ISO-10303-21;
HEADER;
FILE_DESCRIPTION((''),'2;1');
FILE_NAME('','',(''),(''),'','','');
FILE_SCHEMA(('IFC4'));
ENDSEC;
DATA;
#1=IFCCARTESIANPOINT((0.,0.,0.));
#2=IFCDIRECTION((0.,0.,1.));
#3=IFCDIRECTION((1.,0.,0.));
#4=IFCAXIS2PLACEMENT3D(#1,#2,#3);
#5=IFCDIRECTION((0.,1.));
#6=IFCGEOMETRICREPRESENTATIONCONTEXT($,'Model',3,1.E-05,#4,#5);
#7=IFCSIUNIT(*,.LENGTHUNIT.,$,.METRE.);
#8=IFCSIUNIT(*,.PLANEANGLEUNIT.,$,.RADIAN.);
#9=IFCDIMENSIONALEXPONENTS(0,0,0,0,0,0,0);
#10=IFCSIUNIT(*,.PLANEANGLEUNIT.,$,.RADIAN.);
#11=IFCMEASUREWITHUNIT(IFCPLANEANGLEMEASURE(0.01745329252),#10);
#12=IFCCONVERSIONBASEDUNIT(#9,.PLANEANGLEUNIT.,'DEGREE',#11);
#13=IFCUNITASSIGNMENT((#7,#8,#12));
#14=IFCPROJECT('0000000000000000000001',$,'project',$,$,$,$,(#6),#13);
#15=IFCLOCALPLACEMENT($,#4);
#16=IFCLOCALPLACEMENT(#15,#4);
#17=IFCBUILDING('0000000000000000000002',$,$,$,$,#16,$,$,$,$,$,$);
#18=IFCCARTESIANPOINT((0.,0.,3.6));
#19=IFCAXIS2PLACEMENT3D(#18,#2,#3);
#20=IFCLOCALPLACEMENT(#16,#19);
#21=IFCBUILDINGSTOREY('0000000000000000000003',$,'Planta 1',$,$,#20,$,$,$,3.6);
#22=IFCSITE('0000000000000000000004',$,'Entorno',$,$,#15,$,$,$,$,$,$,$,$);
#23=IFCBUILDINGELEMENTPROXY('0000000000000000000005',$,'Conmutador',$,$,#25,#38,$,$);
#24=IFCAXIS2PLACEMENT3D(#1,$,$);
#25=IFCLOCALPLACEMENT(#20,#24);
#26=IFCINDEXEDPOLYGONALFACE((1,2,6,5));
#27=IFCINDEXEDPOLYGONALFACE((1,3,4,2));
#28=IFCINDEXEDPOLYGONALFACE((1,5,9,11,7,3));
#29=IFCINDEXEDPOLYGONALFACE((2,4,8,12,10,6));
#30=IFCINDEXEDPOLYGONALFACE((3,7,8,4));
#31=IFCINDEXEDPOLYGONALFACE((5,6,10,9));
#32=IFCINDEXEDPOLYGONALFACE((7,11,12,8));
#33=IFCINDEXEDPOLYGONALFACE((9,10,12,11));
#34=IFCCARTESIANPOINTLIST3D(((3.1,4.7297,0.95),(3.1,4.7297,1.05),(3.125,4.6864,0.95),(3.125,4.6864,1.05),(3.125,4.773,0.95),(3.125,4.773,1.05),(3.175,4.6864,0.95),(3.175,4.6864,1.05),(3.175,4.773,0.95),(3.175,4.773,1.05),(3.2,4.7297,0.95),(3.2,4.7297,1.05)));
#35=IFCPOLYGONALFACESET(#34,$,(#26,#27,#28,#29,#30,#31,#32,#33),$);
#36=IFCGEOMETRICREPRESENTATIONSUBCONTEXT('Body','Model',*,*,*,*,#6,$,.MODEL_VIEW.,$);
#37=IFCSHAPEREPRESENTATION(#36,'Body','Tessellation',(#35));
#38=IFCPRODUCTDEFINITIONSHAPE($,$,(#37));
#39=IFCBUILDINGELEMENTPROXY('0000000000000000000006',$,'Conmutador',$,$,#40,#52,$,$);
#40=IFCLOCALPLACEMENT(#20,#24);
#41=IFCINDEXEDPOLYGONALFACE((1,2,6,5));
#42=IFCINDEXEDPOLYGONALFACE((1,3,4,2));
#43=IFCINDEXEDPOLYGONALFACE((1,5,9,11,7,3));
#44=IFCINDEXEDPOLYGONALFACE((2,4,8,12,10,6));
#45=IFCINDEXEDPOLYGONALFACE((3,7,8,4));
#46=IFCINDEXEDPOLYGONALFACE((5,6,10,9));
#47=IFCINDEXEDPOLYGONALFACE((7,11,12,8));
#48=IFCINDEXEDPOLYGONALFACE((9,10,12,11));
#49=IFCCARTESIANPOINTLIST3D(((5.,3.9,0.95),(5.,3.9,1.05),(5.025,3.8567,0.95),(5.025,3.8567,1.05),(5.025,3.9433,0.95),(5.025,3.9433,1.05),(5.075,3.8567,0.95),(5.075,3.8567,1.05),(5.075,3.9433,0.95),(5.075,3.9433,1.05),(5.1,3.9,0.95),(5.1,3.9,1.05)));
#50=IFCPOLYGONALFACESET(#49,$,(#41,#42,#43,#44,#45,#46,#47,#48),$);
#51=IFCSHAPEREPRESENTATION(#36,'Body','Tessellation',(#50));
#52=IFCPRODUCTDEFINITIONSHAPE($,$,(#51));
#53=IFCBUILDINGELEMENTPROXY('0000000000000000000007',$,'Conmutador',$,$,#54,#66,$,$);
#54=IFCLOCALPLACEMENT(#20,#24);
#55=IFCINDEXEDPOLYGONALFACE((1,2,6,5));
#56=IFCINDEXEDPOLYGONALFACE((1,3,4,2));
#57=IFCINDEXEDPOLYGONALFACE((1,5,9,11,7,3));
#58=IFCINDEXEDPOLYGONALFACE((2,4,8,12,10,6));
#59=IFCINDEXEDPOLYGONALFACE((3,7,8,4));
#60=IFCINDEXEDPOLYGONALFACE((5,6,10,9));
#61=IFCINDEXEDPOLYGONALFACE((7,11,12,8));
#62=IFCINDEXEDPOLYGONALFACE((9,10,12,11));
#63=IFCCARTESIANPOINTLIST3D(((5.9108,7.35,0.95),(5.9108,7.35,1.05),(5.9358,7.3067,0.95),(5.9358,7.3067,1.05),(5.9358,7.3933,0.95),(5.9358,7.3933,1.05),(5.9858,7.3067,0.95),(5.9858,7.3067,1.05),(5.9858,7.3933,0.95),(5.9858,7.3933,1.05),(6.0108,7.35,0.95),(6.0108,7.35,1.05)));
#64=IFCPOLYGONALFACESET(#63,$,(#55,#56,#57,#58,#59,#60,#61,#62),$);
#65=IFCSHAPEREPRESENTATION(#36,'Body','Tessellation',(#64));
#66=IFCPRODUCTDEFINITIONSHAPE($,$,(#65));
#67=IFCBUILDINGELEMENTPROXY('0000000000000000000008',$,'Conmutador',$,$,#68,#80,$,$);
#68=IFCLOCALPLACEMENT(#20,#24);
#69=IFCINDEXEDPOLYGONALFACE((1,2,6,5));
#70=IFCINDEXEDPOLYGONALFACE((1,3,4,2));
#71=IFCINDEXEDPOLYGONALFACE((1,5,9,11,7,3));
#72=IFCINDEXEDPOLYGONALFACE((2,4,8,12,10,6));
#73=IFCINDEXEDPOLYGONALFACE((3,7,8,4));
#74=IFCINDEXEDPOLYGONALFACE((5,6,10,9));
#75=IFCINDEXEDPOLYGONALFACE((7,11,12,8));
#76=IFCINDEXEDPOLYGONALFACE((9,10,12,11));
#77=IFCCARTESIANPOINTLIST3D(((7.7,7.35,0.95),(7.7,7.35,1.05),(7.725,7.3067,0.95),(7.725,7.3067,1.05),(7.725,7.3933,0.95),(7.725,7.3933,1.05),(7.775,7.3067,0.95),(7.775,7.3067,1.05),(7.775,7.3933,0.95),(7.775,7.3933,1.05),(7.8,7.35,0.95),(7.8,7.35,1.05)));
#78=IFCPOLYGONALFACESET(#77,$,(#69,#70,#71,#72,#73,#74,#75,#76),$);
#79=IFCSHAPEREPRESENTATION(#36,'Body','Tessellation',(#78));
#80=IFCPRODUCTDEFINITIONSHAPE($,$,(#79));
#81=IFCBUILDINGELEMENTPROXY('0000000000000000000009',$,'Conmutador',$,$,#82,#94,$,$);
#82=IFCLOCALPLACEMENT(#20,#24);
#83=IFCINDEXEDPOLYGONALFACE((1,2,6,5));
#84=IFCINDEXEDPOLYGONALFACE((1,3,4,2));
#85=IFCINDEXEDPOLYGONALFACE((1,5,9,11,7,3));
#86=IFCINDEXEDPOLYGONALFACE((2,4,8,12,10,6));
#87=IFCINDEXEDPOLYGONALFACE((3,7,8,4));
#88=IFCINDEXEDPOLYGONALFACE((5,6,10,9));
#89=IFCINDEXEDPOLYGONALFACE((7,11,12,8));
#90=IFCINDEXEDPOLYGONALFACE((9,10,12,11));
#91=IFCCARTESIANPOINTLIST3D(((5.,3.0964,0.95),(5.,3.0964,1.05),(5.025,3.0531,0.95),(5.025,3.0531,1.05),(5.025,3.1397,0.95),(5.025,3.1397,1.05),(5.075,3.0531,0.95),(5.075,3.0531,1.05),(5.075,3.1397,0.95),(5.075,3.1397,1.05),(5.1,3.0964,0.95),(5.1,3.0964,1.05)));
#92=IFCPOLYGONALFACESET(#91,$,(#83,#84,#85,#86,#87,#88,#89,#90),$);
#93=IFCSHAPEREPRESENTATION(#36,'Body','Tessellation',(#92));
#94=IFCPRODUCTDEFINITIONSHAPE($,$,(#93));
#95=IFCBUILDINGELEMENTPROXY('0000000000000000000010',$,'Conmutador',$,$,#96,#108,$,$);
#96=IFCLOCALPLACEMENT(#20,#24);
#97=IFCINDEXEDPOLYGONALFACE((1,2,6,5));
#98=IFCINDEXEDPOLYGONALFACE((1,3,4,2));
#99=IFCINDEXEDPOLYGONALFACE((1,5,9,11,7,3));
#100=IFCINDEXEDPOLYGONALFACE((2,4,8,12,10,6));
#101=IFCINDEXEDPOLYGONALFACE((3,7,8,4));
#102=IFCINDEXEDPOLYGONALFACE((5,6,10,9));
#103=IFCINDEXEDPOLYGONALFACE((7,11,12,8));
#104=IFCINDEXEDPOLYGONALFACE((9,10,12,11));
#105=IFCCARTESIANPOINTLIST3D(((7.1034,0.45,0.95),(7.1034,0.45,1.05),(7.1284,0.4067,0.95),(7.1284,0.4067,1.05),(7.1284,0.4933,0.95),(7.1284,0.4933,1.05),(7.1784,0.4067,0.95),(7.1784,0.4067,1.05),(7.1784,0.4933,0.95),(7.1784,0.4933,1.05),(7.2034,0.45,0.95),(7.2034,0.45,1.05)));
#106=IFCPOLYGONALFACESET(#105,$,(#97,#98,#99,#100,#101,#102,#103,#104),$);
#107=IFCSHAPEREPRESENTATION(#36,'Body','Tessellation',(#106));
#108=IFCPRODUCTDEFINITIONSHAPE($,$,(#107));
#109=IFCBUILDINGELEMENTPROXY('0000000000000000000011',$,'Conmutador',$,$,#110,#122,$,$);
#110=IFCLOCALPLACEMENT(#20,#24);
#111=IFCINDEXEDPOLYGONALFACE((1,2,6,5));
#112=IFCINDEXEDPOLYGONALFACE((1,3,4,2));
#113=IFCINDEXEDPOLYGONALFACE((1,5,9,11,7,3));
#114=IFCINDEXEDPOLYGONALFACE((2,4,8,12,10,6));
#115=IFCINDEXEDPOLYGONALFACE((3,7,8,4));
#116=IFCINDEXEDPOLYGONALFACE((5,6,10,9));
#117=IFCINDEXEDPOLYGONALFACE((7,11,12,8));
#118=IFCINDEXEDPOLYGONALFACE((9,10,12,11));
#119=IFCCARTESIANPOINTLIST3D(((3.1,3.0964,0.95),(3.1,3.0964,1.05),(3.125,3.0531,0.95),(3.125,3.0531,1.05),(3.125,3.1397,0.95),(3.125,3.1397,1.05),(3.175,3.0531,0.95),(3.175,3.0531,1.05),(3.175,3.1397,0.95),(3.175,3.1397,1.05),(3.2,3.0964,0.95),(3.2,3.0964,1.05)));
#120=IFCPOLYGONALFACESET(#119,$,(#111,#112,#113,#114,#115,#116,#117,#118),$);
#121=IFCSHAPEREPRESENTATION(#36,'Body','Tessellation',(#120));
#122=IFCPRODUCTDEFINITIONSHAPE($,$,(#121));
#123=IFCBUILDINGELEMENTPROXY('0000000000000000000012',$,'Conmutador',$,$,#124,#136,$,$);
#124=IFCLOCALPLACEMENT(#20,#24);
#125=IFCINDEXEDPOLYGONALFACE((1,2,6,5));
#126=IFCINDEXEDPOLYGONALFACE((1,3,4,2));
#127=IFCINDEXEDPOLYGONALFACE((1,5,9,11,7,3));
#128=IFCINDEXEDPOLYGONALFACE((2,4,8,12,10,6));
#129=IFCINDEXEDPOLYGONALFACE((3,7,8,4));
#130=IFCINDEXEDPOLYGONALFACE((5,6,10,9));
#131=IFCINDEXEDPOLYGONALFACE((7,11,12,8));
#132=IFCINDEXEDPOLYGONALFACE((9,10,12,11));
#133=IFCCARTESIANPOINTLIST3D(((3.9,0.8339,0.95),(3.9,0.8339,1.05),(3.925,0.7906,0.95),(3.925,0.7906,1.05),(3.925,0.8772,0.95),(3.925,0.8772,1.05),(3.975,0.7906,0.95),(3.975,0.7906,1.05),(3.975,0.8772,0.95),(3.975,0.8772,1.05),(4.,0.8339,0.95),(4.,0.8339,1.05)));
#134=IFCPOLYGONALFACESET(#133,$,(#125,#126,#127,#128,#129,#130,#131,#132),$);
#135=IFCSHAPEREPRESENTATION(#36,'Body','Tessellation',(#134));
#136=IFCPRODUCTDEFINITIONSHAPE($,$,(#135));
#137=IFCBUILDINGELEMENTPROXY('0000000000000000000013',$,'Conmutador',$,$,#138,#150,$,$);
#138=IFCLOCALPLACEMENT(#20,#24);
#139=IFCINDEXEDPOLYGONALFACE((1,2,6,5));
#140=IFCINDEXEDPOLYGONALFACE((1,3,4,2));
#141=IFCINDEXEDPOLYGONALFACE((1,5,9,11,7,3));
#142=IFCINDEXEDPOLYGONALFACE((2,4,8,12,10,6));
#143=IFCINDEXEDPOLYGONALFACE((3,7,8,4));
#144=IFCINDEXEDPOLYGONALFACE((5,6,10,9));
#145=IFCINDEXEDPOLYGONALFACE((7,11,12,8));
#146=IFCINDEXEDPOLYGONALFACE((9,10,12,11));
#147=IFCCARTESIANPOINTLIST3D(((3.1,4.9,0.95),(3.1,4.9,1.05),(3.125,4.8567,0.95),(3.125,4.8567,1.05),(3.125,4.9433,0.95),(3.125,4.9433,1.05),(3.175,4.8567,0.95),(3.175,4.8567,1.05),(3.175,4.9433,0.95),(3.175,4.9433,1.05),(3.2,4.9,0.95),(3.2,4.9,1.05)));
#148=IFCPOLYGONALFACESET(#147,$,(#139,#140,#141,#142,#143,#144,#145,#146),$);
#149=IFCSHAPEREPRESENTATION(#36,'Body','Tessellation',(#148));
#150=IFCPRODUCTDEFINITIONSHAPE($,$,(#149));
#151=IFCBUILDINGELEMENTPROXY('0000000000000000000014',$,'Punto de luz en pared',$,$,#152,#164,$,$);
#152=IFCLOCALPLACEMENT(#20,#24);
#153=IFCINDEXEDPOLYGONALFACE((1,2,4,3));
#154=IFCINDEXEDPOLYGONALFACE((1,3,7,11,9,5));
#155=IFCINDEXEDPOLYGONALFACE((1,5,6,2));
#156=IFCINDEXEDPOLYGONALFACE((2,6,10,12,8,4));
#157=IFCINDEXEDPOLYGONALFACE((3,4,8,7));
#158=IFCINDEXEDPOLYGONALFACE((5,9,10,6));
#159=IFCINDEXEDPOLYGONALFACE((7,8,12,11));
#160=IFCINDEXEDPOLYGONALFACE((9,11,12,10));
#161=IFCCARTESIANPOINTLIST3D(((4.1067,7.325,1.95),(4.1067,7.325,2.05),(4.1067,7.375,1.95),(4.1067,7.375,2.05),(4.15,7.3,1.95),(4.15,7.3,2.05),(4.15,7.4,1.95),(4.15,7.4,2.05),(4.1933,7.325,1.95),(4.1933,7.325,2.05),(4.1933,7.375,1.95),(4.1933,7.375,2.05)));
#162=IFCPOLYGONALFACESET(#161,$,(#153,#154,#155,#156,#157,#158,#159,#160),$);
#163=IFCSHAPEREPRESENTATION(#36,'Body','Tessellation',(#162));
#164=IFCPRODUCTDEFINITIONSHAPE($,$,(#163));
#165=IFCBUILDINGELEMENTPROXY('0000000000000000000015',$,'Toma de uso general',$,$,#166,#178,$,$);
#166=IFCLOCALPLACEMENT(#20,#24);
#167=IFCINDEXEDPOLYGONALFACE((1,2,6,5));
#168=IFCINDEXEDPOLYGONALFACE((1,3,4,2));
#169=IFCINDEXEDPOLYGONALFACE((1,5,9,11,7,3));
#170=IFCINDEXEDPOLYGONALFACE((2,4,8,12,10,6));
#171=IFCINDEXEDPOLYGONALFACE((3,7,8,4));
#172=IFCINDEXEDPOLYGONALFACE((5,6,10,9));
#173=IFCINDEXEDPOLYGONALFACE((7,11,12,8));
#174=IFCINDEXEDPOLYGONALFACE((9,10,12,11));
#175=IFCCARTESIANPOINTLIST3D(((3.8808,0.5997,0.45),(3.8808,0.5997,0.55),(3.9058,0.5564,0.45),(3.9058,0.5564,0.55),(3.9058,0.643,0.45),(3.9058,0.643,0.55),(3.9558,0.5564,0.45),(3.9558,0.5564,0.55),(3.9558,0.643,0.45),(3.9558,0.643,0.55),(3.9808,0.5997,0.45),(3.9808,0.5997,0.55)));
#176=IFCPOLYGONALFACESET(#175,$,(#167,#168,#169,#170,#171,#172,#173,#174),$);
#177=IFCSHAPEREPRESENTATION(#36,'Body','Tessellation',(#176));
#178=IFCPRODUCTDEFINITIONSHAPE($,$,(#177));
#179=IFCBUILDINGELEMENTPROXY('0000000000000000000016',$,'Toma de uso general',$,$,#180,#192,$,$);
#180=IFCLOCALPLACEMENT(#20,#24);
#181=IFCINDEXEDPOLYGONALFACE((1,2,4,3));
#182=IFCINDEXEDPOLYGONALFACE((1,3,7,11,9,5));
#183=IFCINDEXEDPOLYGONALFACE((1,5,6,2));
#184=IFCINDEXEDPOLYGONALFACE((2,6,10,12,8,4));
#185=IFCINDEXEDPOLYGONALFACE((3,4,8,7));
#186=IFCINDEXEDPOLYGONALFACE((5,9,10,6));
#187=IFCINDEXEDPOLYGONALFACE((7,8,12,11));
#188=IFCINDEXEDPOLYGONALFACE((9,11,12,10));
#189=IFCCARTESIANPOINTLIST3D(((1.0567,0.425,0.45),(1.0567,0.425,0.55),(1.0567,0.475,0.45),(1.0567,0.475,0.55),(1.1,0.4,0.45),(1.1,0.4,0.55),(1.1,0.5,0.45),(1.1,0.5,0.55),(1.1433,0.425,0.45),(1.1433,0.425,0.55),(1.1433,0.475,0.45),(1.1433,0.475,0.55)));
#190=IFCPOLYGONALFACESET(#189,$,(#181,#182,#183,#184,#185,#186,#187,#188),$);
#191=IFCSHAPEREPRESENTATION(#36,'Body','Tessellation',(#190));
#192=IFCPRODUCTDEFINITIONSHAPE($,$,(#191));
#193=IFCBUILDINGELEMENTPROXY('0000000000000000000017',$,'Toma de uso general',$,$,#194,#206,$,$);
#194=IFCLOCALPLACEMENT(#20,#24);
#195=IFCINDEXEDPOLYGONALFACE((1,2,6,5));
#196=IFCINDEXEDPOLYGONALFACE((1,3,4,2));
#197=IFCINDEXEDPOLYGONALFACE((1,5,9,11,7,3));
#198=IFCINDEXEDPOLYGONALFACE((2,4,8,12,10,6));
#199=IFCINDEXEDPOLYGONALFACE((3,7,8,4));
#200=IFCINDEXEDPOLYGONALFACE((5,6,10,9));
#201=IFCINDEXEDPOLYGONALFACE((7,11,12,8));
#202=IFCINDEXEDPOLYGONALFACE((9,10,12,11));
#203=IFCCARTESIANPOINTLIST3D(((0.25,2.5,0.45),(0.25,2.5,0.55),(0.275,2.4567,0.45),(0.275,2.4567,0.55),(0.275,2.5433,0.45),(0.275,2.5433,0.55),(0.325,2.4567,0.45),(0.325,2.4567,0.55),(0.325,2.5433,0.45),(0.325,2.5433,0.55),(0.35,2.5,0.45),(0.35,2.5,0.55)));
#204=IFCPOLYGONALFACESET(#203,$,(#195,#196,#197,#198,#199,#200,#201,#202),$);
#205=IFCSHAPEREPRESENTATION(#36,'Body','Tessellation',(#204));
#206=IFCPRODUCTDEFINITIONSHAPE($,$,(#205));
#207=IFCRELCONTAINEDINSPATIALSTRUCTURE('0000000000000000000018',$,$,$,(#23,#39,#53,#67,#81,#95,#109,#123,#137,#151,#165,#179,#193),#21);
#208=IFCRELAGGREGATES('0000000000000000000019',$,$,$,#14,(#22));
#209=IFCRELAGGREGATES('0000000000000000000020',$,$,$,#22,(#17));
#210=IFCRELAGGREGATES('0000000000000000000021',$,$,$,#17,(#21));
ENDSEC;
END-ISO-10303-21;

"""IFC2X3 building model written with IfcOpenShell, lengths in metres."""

from ifc_helpers import new_model, entity, si_unit, converted_unit, direction, frame, origin_with_axes, place, context, subcontext, project, spatial, polyline, outline, extrude, source, transform, mapped, element, save


model = new_model("IFC2X3")

# Units and contexts
model_context = context("Model", 3, precision=1e-05, world=origin_with_axes(), true_north=direction((0.0, 1.0)))
body_context = subcontext(model_context, "Body", "Model", "MODEL_VIEW")
ifc_project = project(units=[si_unit("LENGTHUNIT", "METRE"), si_unit("PLANEANGLEUNIT", "RADIAN"), converted_unit("PLANEANGLEUNIT", "DEGREE", entity("IfcPlaneAngleMeasure", 0.01745329252), si_unit("PLANEANGLEUNIT", "RADIAN"), dimensions=[0, 0, 0, 0, 0, 0, 0])], contexts=[model_context])

# Site, building, storey
site_placement = place(None, origin_with_axes())
site = spatial("IfcSite", under=ifc_project, at=site_placement, Name="Entorno")
building_placement = place(site_placement, origin_with_axes())
building = spatial("IfcBuilding", under=site, at=building_placement)
storey_placement = place(building_placement, frame((0.0, 0.0, 3.6), z_axis=(0.0, 0.0, 1.0), x_axis=(1.0, 0.0, 0.0)))
storey = spatial("IfcBuildingStorey", under=building, at=storey_placement, Name="Planta 1", Elevation=3.6)

# Building element proxies
shared_shape_1 = source(origin_with_axes(), body_context, "Body", "SolidModel", [
    extrude(outline(polyline([(0.05, 0.0), (0.025, 0.0433), (-0.025, 0.0433), (-0.05, 0.0), (-0.025, -0.0433), (0.025, -0.0433), (0.05, 0.0)])), frame((0.0, 0.0, -0.05), z_axis=(0.0, 0.0, 1.0), x_axis=(1.0, 0.0, 0.0)), (0.0, 0.0, 1.0), 0.1),
])
proxy_1_placement = place(storey_placement, frame((0.0, 0.0, -3.6), z_axis=(0.0, 0.0, 1.0), x_axis=(1.0, 0.0, 0.0)))
element("IfcBuildingElementProxy", 1, at=proxy_1_placement, inside=storey, Name="Conmutador", context=body_context, shape_type="Brep", body=[
    mapped(shared_shape_1, transform((3.15, 4.7297, 4.6), x_axis=(1.0, 0.0, 0.0), y_axis=(0.0, 1.0, 0.0), z_axis=(0.0, 0.0, 1.0))),
])
proxy_2_placement = place(storey_placement, frame((0.0, 0.0, -3.6), z_axis=(0.0, 0.0, 1.0), x_axis=(1.0, 0.0, 0.0)))
element("IfcBuildingElementProxy", 2, at=proxy_2_placement, inside=storey, Name="Conmutador", context=body_context, shape_type="Brep", body=[
    mapped(shared_shape_1, transform((5.05, 3.9, 4.6), x_axis=(1.0, 0.0, 0.0), y_axis=(0.0, 1.0, 0.0), z_axis=(0.0, 0.0, 1.0))),
])
proxy_3_placement = place(storey_placement, frame((0.0, 0.0, -3.6), z_axis=(0.0, 0.0, 1.0), x_axis=(1.0, 0.0, 0.0)))
element("IfcBuildingElementProxy", 3, at=proxy_3_placement, inside=storey, Name="Conmutador", context=body_context, shape_type="Brep", body=[
    mapped(shared_shape_1, transform((5.9608, 7.35, 4.6), x_axis=(1.0, 0.0, 0.0), y_axis=(0.0, 1.0, 0.0), z_axis=(0.0, 0.0, 1.0))),
])
proxy_4_placement = place(storey_placement, frame((0.0, 0.0, -3.6), z_axis=(0.0, 0.0, 1.0), x_axis=(1.0, 0.0, 0.0)))
element("IfcBuildingElementProxy", 4, at=proxy_4_placement, inside=storey, Name="Conmutador", context=body_context, shape_type="Brep", body=[
    mapped(shared_shape_1, transform((7.75, 7.35, 4.6), x_axis=(1.0, 0.0, 0.0), y_axis=(0.0, 1.0, 0.0), z_axis=(0.0, 0.0, 1.0))),
])
proxy_5_placement = place(storey_placement, frame((0.0, 0.0, -3.6), z_axis=(0.0, 0.0, 1.0), x_axis=(1.0, 0.0, 0.0)))
element("IfcBuildingElementProxy", 5, at=proxy_5_placement, inside=storey, Name="Conmutador", context=body_context, shape_type="Brep", body=[
    mapped(shared_shape_1, transform((5.05, 3.0964, 4.6), x_axis=(1.0, 0.0, 0.0), y_axis=(0.0, 1.0, 0.0), z_axis=(0.0, 0.0, 1.0))),
])
proxy_6_placement = place(storey_placement, frame((0.0, 0.0, -3.6), z_axis=(0.0, 0.0, 1.0), x_axis=(1.0, 0.0, 0.0)))
element("IfcBuildingElementProxy", 6, at=proxy_6_placement, inside=storey, Name="Conmutador", context=body_context, shape_type="Brep", body=[
    mapped(shared_shape_1, transform((7.1534, 0.45, 4.6), x_axis=(1.0, 0.0, 0.0), y_axis=(0.0, 1.0, 0.0), z_axis=(0.0, 0.0, 1.0))),
])
proxy_7_placement = place(storey_placement, frame((0.0, 0.0, -3.6), z_axis=(0.0, 0.0, 1.0), x_axis=(1.0, 0.0, 0.0)))
element("IfcBuildingElementProxy", 7, at=proxy_7_placement, inside=storey, Name="Conmutador", context=body_context, shape_type="Brep", body=[
    mapped(shared_shape_1, transform((3.15, 3.0964, 4.6), x_axis=(1.0, 0.0, 0.0), y_axis=(0.0, 1.0, 0.0), z_axis=(0.0, 0.0, 1.0))),
])
proxy_8_placement = place(storey_placement, frame((0.0, 0.0, -3.6), z_axis=(0.0, 0.0, 1.0), x_axis=(1.0, 0.0, 0.0)))
element("IfcBuildingElementProxy", 8, at=proxy_8_placement, inside=storey, Name="Conmutador", context=body_context, shape_type="Brep", body=[
    mapped(shared_shape_1, transform((3.95, 0.8339, 4.6), x_axis=(1.0, 0.0, 0.0), y_axis=(0.0, 1.0, 0.0), z_axis=(0.0, 0.0, 1.0))),
])
proxy_9_placement = place(storey_placement, frame((0.0, 0.0, -3.6), z_axis=(0.0, 0.0, 1.0), x_axis=(1.0, 0.0, 0.0)))
element("IfcBuildingElementProxy", 9, at=proxy_9_placement, inside=storey, Name="Conmutador", context=body_context, shape_type="Brep", body=[
    mapped(shared_shape_1, transform((3.15, 4.9, 4.6), x_axis=(1.0, 0.0, 0.0), y_axis=(0.0, 1.0, 0.0), z_axis=(0.0, 0.0, 1.0))),
])
shared_shape_2 = source(origin_with_axes(), body_context, "Body", "SolidModel", [
    extrude(outline(polyline([(0.05, 0.0), (0.025, 0.0433), (-0.025, 0.0433), (-0.05, 0.0), (-0.025, -0.0433), (0.025, -0.0433), (0.05, 0.0)])), frame((0.0, 0.0, -0.05), z_axis=(0.0, 0.0, 1.0), x_axis=(1.0, 0.0, 0.0)), (0.0, 0.0, 1.0), 0.1),
])
proxy_10_placement = place(storey_placement, frame((0.0, 0.0, -3.6), z_axis=(0.0, 0.0, 1.0), x_axis=(1.0, 0.0, 0.0)))
element("IfcBuildingElementProxy", 10, at=proxy_10_placement, inside=storey, Name="Punto de luz en pared", context=body_context, shape_type="Brep", body=[
    mapped(shared_shape_2, transform((4.15, 7.35, 5.6), x_axis=(0.0, -1.0, 0.0), y_axis=(1.0, 0.0, 0.0), z_axis=(0.0, 0.0, 1.0))),
])
shared_shape_3 = source(origin_with_axes(), body_context, "Body", "SolidModel", [
    extrude(outline(polyline([(0.05, 0.0), (0.025, 0.0433), (-0.025, 0.0433), (-0.05, 0.0), (-0.025, -0.0433), (0.025, -0.0433), (0.05, 0.0)])), frame((0.0, 0.0, -0.05), z_axis=(0.0, 0.0, 1.0), x_axis=(1.0, 0.0, 0.0)), (0.0, 0.0, 1.0), 0.1),
])
proxy_11_placement = place(storey_placement, frame((0.0, 0.0, -3.6), z_axis=(0.0, 0.0, 1.0), x_axis=(1.0, 0.0, 0.0)))
element("IfcBuildingElementProxy", 11, at=proxy_11_placement, inside=storey, Name="Toma de uso general", context=body_context, shape_type="Brep", body=[
    mapped(shared_shape_3, transform((3.9308, 0.5997, 4.1), x_axis=(-1.0, 0.0, 0.0), y_axis=(0.0, -1.0, 0.0), z_axis=(0.0, 0.0, 1.0))),
])
proxy_12_placement = place(storey_placement, frame((0.0, 0.0, -3.6), z_axis=(0.0, 0.0, 1.0), x_axis=(1.0, 0.0, 0.0)))
element("IfcBuildingElementProxy", 12, at=proxy_12_placement, inside=storey, Name="Toma de uso general", context=body_context, shape_type="Brep", body=[
    mapped(shared_shape_3, transform((1.1, 0.45, 4.1), x_axis=(0.0, 1.0, 0.0), y_axis=(-1.0, 0.0, 0.0), z_axis=(0.0, 0.0, 1.0))),
])
proxy_13_placement = place(storey_placement, frame((0.0, 0.0, -3.6), z_axis=(0.0, 0.0, 1.0), x_axis=(1.0, 0.0, 0.0)))
element("IfcBuildingElementProxy", 13, at=proxy_13_placement, inside=storey, Name="Toma de uso general", context=body_context, shape_type="Brep", body=[
    mapped(shared_shape_3, transform((0.3, 2.5, 4.1), x_axis=(1.0, 0.0, 0.0), y_axis=(0.0, 1.0, 0.0), z_axis=(0.0, 0.0, 1.0))),
])

save(model, "model.ifc")
